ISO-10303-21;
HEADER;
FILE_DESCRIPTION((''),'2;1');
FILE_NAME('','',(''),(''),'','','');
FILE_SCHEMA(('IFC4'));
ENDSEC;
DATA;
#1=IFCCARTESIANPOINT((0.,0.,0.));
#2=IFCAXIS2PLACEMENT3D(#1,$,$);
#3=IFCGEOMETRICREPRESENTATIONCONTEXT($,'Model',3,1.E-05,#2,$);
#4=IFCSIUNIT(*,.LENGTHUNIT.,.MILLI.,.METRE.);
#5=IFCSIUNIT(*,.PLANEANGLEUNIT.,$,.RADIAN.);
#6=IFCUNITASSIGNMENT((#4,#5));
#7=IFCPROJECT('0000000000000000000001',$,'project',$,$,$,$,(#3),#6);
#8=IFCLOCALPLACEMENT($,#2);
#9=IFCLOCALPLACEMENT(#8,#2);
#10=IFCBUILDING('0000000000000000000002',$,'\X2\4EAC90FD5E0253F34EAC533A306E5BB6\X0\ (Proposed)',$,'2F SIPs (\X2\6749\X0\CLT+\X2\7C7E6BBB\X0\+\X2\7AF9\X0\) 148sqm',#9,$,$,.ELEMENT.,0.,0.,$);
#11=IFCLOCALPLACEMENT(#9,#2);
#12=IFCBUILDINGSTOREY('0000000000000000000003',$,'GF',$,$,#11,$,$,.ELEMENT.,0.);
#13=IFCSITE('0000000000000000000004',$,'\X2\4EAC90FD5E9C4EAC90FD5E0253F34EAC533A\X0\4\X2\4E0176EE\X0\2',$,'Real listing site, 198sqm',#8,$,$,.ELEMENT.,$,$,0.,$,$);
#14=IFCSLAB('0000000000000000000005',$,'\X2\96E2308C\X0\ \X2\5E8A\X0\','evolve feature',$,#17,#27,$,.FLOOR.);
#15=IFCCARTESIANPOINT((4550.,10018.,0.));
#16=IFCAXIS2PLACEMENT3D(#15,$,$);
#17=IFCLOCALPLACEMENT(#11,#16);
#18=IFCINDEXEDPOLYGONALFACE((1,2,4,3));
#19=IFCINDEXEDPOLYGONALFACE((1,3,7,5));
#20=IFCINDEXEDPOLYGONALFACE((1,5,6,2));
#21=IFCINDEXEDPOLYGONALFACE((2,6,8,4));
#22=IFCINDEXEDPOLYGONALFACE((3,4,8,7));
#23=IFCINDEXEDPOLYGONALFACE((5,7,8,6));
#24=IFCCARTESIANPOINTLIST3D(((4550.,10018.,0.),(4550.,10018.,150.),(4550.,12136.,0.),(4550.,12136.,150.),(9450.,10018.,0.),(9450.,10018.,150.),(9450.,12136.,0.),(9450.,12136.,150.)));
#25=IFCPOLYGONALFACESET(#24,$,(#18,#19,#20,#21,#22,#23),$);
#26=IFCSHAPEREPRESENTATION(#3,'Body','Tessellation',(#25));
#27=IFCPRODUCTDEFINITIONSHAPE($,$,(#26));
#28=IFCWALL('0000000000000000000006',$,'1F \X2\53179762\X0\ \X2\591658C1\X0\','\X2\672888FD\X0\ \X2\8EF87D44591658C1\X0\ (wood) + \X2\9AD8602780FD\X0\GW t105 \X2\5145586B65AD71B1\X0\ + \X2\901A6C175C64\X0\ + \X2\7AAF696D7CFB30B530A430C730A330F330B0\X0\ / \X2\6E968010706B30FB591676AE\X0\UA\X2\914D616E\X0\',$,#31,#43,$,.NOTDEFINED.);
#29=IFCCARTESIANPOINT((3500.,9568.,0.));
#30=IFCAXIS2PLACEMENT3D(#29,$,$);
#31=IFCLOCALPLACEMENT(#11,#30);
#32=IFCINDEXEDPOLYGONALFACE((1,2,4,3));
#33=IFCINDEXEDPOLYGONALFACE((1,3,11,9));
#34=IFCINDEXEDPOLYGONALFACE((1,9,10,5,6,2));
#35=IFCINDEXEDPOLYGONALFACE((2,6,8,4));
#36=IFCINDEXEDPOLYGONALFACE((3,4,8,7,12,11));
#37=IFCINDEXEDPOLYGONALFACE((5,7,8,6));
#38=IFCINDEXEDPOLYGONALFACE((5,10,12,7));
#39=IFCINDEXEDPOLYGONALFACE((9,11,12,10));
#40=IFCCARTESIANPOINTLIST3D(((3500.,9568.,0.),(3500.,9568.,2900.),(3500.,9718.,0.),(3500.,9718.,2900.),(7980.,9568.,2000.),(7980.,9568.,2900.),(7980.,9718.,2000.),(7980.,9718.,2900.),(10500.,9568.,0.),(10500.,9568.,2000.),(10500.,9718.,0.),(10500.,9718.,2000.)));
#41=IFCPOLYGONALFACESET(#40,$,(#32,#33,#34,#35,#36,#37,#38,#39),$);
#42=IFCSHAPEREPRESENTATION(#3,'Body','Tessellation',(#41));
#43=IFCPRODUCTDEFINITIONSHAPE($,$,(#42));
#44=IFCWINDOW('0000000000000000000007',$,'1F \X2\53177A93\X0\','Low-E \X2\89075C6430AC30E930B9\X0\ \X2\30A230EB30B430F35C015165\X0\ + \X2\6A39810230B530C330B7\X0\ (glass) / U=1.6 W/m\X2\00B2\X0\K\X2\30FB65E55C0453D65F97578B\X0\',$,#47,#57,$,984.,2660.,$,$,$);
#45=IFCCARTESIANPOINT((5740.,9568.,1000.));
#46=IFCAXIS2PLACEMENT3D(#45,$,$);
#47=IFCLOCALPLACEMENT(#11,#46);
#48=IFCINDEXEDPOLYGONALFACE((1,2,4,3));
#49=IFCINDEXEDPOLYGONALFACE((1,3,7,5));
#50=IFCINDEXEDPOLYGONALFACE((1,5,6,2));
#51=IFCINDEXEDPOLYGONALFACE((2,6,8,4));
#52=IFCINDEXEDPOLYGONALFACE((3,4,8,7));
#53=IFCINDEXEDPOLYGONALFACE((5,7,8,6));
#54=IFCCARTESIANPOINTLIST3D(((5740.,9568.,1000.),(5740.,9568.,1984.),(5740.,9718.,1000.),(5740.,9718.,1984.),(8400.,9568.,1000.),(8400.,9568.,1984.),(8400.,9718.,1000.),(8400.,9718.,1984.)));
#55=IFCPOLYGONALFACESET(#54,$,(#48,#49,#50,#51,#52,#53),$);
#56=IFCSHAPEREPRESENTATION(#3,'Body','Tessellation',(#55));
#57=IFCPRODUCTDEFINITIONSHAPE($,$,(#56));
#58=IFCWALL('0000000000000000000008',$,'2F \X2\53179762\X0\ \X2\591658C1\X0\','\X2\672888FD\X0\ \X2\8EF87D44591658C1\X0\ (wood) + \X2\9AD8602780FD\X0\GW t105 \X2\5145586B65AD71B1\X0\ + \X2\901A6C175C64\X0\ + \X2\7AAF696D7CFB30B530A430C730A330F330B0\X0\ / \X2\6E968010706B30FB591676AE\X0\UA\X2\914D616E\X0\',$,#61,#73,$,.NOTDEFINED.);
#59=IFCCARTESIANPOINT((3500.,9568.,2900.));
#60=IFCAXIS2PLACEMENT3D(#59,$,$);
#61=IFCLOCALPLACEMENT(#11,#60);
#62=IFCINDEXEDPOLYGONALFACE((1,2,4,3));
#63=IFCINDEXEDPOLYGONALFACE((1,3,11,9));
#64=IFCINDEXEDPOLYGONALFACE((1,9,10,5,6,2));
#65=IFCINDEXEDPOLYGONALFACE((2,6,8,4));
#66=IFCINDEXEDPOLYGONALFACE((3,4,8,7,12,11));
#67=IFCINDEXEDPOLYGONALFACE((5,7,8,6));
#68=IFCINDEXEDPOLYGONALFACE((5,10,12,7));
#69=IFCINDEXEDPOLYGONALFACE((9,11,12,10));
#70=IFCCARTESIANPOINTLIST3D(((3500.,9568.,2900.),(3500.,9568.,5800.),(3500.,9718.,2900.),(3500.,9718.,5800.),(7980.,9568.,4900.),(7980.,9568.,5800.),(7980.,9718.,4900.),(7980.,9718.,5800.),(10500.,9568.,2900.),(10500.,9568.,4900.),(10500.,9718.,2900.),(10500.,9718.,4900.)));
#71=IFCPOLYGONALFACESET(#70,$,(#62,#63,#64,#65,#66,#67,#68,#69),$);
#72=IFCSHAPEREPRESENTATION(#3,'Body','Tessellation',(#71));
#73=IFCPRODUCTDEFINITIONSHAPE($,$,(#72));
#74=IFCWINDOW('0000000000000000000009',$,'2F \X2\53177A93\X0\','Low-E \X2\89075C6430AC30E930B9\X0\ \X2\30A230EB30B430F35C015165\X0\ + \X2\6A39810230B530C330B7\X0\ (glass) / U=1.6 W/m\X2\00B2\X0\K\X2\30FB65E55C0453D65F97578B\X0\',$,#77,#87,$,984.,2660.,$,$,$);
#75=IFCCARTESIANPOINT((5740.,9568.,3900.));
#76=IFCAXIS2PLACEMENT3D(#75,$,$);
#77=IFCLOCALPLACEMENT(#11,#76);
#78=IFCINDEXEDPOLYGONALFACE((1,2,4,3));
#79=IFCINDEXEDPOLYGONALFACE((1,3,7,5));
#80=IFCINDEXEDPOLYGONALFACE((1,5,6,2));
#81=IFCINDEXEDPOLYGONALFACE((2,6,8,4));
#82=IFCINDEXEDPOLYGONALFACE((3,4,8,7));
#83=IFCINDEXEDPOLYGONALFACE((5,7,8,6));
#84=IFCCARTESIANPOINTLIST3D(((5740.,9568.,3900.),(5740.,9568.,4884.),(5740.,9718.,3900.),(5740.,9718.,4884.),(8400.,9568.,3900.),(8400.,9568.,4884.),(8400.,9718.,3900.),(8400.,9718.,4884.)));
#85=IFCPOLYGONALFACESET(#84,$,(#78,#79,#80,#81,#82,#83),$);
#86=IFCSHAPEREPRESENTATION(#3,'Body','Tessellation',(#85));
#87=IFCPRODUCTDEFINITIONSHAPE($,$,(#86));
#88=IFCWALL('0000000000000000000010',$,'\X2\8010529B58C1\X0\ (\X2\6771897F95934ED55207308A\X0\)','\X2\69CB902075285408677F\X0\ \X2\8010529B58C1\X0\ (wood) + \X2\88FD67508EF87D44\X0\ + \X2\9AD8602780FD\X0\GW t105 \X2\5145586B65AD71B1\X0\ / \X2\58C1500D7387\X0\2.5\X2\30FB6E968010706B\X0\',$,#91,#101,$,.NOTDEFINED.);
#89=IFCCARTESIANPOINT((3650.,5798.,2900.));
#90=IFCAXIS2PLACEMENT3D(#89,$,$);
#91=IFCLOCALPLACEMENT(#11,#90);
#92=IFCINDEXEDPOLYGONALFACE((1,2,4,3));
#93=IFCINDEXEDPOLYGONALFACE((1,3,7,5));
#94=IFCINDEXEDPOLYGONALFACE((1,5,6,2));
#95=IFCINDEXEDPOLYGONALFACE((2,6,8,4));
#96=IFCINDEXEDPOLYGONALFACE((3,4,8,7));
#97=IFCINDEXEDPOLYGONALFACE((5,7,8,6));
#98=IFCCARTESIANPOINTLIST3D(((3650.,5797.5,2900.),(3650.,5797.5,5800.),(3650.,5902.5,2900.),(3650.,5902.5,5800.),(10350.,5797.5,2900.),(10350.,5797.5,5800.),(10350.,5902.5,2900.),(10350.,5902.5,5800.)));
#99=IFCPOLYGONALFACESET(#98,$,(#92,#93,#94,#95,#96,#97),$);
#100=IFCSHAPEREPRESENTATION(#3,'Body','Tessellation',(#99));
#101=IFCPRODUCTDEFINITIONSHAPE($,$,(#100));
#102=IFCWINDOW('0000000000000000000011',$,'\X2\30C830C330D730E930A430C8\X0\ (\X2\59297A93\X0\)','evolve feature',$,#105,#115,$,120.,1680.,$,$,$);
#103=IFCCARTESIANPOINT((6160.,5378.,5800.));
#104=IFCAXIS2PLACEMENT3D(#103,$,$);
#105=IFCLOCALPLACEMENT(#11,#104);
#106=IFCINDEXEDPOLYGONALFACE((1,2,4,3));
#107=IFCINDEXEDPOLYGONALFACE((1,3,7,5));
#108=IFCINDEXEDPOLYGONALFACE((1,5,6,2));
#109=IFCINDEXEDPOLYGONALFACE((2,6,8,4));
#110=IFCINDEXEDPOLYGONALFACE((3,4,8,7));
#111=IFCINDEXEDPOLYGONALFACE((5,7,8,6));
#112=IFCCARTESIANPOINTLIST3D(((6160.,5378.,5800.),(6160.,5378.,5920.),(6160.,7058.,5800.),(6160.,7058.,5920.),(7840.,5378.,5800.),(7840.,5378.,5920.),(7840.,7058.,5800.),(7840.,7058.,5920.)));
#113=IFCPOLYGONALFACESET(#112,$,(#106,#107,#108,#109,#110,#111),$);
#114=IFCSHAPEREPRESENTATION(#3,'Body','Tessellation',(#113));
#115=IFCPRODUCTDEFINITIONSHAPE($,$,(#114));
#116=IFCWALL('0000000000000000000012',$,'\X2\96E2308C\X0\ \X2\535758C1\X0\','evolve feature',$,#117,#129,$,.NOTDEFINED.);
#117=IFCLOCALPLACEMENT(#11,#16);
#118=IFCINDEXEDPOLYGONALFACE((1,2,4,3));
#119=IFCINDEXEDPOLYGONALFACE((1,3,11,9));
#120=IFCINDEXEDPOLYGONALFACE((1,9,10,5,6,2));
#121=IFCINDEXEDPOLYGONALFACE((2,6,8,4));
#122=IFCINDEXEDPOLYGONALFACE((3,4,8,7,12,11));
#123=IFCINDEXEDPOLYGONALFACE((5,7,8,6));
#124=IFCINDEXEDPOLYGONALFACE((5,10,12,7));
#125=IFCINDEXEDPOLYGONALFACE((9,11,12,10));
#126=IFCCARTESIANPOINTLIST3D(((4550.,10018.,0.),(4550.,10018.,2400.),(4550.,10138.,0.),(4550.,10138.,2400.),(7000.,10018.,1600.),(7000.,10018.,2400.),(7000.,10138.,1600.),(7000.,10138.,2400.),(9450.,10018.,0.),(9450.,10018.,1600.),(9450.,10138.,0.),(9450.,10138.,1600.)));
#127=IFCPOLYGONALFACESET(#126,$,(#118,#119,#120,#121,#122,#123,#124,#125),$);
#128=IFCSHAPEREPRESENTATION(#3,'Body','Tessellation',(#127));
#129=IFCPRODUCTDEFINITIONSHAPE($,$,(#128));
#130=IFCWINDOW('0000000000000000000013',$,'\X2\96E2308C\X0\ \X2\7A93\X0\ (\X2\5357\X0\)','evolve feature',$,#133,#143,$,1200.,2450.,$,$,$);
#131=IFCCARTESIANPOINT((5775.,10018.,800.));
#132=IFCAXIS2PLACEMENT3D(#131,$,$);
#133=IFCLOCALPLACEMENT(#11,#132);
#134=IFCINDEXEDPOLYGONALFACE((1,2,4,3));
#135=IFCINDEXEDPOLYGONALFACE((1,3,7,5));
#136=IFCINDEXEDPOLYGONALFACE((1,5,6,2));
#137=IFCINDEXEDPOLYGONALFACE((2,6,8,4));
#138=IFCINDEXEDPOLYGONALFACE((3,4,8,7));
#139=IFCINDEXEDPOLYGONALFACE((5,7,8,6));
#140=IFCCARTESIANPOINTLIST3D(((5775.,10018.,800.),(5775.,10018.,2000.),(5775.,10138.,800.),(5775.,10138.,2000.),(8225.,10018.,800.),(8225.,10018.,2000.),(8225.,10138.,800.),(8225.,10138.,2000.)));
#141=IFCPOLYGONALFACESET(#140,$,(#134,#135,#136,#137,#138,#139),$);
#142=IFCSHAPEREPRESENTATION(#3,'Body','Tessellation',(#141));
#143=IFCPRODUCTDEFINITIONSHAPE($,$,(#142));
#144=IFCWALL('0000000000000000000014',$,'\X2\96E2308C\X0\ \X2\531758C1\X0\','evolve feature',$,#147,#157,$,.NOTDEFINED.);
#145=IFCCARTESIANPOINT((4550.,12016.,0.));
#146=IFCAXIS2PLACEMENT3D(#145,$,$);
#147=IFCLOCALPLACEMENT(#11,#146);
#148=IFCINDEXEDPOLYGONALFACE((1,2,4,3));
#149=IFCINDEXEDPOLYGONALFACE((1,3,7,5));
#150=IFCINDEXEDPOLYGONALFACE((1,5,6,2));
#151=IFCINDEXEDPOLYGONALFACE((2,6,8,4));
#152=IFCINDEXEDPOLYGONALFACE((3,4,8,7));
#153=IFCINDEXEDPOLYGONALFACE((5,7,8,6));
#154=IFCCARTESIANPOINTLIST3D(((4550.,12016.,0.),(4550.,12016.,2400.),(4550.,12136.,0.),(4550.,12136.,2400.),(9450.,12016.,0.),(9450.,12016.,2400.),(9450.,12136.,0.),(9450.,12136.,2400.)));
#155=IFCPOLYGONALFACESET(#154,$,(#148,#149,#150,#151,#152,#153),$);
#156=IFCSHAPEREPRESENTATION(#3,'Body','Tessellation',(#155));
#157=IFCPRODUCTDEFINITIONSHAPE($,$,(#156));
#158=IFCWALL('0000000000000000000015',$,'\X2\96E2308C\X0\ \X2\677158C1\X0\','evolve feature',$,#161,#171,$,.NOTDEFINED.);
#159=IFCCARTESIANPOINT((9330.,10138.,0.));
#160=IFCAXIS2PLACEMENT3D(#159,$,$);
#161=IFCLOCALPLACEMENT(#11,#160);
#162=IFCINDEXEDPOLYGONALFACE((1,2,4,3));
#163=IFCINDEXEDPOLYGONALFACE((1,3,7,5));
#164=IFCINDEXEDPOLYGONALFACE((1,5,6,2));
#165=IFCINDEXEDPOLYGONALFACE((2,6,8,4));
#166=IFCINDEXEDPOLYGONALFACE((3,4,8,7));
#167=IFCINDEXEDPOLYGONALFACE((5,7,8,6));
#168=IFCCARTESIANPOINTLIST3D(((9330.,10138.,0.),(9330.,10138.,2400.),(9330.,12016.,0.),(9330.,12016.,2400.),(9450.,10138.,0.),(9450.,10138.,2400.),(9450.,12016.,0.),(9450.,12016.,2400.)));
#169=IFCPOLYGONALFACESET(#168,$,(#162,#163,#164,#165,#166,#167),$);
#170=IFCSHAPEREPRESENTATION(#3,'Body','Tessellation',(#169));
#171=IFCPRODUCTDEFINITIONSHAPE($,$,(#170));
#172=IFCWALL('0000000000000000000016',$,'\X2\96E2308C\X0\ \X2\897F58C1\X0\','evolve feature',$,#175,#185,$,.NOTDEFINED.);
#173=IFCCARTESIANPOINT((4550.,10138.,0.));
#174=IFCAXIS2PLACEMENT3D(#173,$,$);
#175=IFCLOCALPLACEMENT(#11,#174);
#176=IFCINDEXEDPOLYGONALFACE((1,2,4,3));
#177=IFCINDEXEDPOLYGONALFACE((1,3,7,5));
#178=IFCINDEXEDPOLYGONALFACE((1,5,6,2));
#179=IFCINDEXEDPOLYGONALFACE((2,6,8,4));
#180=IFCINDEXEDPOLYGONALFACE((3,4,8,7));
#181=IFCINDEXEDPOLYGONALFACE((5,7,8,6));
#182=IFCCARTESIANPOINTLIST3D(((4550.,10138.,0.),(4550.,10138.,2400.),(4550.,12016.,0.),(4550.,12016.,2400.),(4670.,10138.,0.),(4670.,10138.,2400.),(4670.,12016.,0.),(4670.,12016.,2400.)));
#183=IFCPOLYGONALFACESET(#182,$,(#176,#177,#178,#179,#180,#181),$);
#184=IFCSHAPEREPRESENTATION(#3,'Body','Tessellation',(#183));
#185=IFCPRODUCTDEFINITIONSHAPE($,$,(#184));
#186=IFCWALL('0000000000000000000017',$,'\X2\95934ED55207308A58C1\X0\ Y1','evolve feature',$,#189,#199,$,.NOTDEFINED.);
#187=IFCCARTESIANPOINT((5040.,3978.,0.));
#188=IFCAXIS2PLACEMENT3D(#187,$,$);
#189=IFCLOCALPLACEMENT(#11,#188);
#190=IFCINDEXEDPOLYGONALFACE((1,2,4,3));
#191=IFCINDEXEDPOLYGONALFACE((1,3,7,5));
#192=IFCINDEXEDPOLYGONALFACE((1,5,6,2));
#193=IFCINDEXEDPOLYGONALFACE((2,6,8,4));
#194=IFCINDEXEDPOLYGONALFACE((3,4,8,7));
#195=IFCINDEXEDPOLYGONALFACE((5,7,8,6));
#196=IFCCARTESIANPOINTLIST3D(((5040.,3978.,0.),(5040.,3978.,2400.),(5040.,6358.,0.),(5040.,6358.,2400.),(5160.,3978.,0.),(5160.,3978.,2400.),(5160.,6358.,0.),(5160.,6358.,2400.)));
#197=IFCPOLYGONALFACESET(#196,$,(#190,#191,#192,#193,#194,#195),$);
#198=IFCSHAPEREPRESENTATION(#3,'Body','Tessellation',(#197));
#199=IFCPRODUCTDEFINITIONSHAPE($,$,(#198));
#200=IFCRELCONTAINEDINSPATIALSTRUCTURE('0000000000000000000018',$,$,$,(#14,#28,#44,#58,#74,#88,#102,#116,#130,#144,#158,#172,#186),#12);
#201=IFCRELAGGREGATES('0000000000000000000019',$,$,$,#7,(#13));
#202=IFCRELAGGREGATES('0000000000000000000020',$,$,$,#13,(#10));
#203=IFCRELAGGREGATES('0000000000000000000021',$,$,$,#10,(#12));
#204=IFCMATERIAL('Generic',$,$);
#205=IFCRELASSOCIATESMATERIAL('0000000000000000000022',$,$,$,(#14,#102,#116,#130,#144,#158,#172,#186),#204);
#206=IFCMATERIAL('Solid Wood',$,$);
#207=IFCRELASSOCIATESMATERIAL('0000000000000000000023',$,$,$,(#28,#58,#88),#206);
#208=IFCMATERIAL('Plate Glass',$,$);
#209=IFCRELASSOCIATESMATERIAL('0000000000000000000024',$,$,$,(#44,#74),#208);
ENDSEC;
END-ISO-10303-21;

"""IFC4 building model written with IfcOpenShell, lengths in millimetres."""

from ifc_helpers import new_model, si_unit, frame, frame_2d, origin, place, context, project, spatial, rectangle, extrude, material, element, fill, save


model = new_model("IFC4")

# Units and contexts
model_context = context("Model", 3, precision=1e-05, world=origin())
ifc_project = project(units=[si_unit("LENGTHUNIT", "METRE", prefix="MILLI"), si_unit("PLANEANGLEUNIT", "RADIAN")], contexts=[model_context])

# Site, building, storey
site_placement = place(None, origin())
site = spatial("IfcSite", under=ifc_project, at=site_placement, Name="京都府京都市右京区4丁目2", ObjectType="Real listing site, 198sqm", CompositionType="ELEMENT", RefElevation=0.0)
building_placement = place(site_placement, origin())
building = spatial("IfcBuilding", under=site, at=building_placement, Name="京都市右京区の家 (Proposed)", ObjectType="2F SIPs (杉CLT+籾殻+竹) 148sqm", CompositionType="ELEMENT", ElevationOfRefHeight=0.0, ElevationOfTerrain=0.0)
storey_placement = place(building_placement, origin())
storey = spatial("IfcBuildingStorey", under=building, at=storey_placement, Name="GF", CompositionType="ELEMENT", Elevation=0.0)

# Slab
ifc_material_1 = material(Name="Generic")
slab_placement = place(storey_placement, frame((4550.0, 10018.0, 0.0)))
element("IfcSlab", 1, at=slab_placement, inside=storey, material=ifc_material_1, Name="離れ 床", Description="evolve feature", PredefinedType="FLOOR", context=model_context, shape_type="SweptSolid", body=[
    extrude(rectangle(XDim=4900.0, YDim=2118.0, at=frame_2d((2450.0, 1059.0))), frame((4550.0, 10018.0, 0.0)), (0.0, 0.0, 1.0), 150.0),
])

# Wall, opening, window
ifc_material_2 = material(Name="Solid Wood")
wall_1_placement = place(storey_placement, frame((3500.0, 9568.0, 0.0)))
wall_1 = element("IfcWall", 2, at=wall_1_placement, inside=storey, material=ifc_material_2, Name="1F 北面 外壁", Description="木製 軸組外壁 (wood) + 高性能GW t105 充填断熱 + 通気層 + 窯業系サイディング / 準耐火・外皮UA配慮", PredefinedType="NOTDEFINED", context=model_context, shape_type="SweptSolid", body=[
    extrude(rectangle(XDim=7000.0, YDim=150.0, at=frame_2d((3500.0, 75.0))), frame((3500.0, 9568.0, 0.0)), (0.0, 0.0, 1.0), 2900.0),
])
opening_1_placement = place(storey_placement, frame((5740.0, 9568.0, 1000.0)))
opening_1 = element("IfcOpeningElement", 3, at=opening_1_placement, cuts=wall_1, PredefinedType="NOTDEFINED", context=model_context, shape_type="SweptSolid", body=[
    extrude(rectangle(XDim=2660.0, YDim=150.0, at=frame_2d((1330.0, 75.0))), frame((5740.0, 9568.0, 1000.0)), (0.0, 0.0, 1.0), 984.0),
])
ifc_material_3 = material(Name="Plate Glass")
window_1_placement = place(storey_placement, frame((5740.0, 9568.0, 1000.0)))
window_1 = element("IfcWindow", 4, at=window_1_placement, inside=storey, material=ifc_material_3, Name="1F 北窓", Description="Low-E 複層ガラス アルゴン封入 + 樹脂サッシ (glass) / U=1.6 W/m²K・日射取得型", OverallHeight=984.0, OverallWidth=2660.0, context=model_context, shape_type="SweptSolid", body=[
    extrude(rectangle(XDim=2660.0, YDim=150.0, at=frame_2d((1330.0, 75.0))), frame((5740.0, 9568.0, 1000.0)), (0.0, 0.0, 1.0), 984.0),
])
fill(opening_1, window_1)

# Wall, opening, window
wall_2_placement = place(storey_placement, frame((3500.0, 9568.0, 2900.0)))
wall_2 = element("IfcWall", 5, at=wall_2_placement, inside=storey, material=ifc_material_2, Name="2F 北面 外壁", Description="木製 軸組外壁 (wood) + 高性能GW t105 充填断熱 + 通気層 + 窯業系サイディング / 準耐火・外皮UA配慮", PredefinedType="NOTDEFINED", context=model_context, shape_type="SweptSolid", body=[
    extrude(rectangle(XDim=7000.0, YDim=150.0, at=frame_2d((3500.0, 75.0))), frame((3500.0, 9568.0, 2900.0)), (0.0, 0.0, 1.0), 2900.0),
])
opening_2_placement = place(storey_placement, frame((5740.0, 9568.0, 3900.0)))
opening_2 = element("IfcOpeningElement", 6, at=opening_2_placement, cuts=wall_2, PredefinedType="NOTDEFINED", context=model_context, shape_type="SweptSolid", body=[
    extrude(rectangle(XDim=2660.0, YDim=150.0, at=frame_2d((1330.0, 75.0))), frame((5740.0, 9568.0, 3900.0)), (0.0, 0.0, 1.0), 984.0),
])
window_2_placement = place(storey_placement, frame((5740.0, 9568.0, 3900.0)))
window_2 = element("IfcWindow", 7, at=window_2_placement, inside=storey, material=ifc_material_3, Name="2F 北窓", Description="Low-E 複層ガラス アルゴン封入 + 樹脂サッシ (glass) / U=1.6 W/m²K・日射取得型", OverallHeight=984.0, OverallWidth=2660.0, context=model_context, shape_type="SweptSolid", body=[
    extrude(rectangle(XDim=2660.0, YDim=150.0, at=frame_2d((1330.0, 75.0))), frame((5740.0, 9568.0, 3900.0)), (0.0, 0.0, 1.0), 984.0),
])
fill(opening_2, window_2)

# Wall
wall_3_placement = place(storey_placement, frame((3650.0, 5798.0, 2900.0)))
element("IfcWall", 8, at=wall_3_placement, inside=storey, material=ifc_material_2, Name="耐力壁 (東西間仕切り)", Description="構造用合板 耐力壁 (wood) + 製材軸組 + 高性能GW t105 充填断熱 / 壁倍率2.5・準耐火", PredefinedType="NOTDEFINED", context=model_context, shape_type="SweptSolid", body=[
    extrude(rectangle(XDim=6700.0, YDim=105.0, at=frame_2d((3350.0, 52.0))), frame((3650.0, 5798.0, 2900.0)), (0.0, 0.0, 1.0), 2900.0),
])

# Window
window_3_placement = place(storey_placement, frame((6160.0, 5378.0, 5800.0)))
element("IfcWindow", 9, at=window_3_placement, inside=storey, material=ifc_material_1, Name="トップライト (天窓)", Description="evolve feature", OverallHeight=120.0, OverallWidth=1680.0, context=model_context, shape_type="SweptSolid", body=[
    extrude(rectangle(XDim=1680.0, YDim=1680.0, at=frame_2d((840.0, 840.0))), frame((6160.0, 5378.0, 5800.0)), (0.0, 0.0, 1.0), 120.0),
])

# Wall, opening, window
wall_4_placement = place(storey_placement, frame((4550.0, 10018.0, 0.0)))
wall_4 = element("IfcWall", 10, at=wall_4_placement, inside=storey, material=ifc_material_1, Name="離れ 南壁", Description="evolve feature", PredefinedType="NOTDEFINED", context=model_context, shape_type="SweptSolid", body=[
    extrude(rectangle(XDim=4900.0, YDim=120.0, at=frame_2d((2450.0, 60.0))), frame((4550.0, 10018.0, 0.0)), (0.0, 0.0, 1.0), 2400.0),
])
opening_3_placement = place(storey_placement, frame((5775.0, 10018.0, 800.0)))
opening_3 = element("IfcOpeningElement", 11, at=opening_3_placement, cuts=wall_4, PredefinedType="NOTDEFINED", context=model_context, shape_type="SweptSolid", body=[
    extrude(rectangle(XDim=2450.0, YDim=120.0, at=frame_2d((1225.0, 60.0))), frame((5775.0, 10018.0, 800.0)), (0.0, 0.0, 1.0), 1200.0),
])
window_4_placement = place(storey_placement, frame((5775.0, 10018.0, 800.0)))
window_4 = element("IfcWindow", 12, at=window_4_placement, inside=storey, material=ifc_material_1, Name="離れ 窓 (南)", Description="evolve feature", OverallHeight=1200.0, OverallWidth=2450.0, context=model_context, shape_type="SweptSolid", body=[
    extrude(rectangle(XDim=2450.0, YDim=120.0, at=frame_2d((1225.0, 60.0))), frame((5775.0, 10018.0, 800.0)), (0.0, 0.0, 1.0), 1200.0),
])
fill(opening_3, window_4)

# Walls
wall_5_placement = place(storey_placement, frame((4550.0, 12016.0, 0.0)))
element("IfcWall", 13, at=wall_5_placement, inside=storey, material=ifc_material_1, Name="離れ 北壁", Description="evolve feature", PredefinedType="NOTDEFINED", context=model_context, shape_type="SweptSolid", body=[
    extrude(rectangle(XDim=4900.0, YDim=120.0, at=frame_2d((2450.0, 60.0))), frame((4550.0, 12016.0, 0.0)), (0.0, 0.0, 1.0), 2400.0),
])
wall_6_placement = place(storey_placement, frame((9330.0, 10138.0, 0.0)))
element("IfcWall", 14, at=wall_6_placement, inside=storey, material=ifc_material_1, Name="離れ 東壁", Description="evolve feature", PredefinedType="NOTDEFINED", context=model_context, shape_type="SweptSolid", body=[
    extrude(rectangle(XDim=120.0, YDim=1878.0, at=frame_2d((60.0, 939.0))), frame((9330.0, 10138.0, 0.0)), (0.0, 0.0, 1.0), 2400.0),
])
wall_7_placement = place(storey_placement, frame((4550.0, 10138.0, 0.0)))
element("IfcWall", 15, at=wall_7_placement, inside=storey, material=ifc_material_1, Name="離れ 西壁", Description="evolve feature", PredefinedType="NOTDEFINED", context=model_context, shape_type="SweptSolid", body=[
    extrude(rectangle(XDim=120.0, YDim=1878.0, at=frame_2d((60.0, 939.0))), frame((4550.0, 10138.0, 0.0)), (0.0, 0.0, 1.0), 2400.0),
])
wall_8_placement = place(storey_placement, frame((5040.0, 3978.0, 0.0)))
element("IfcWall", 16, at=wall_8_placement, inside=storey, material=ifc_material_1, Name="間仕切り壁 Y1", Description="evolve feature", PredefinedType="NOTDEFINED", context=model_context, shape_type="SweptSolid", body=[
    extrude(rectangle(XDim=120.0, YDim=2380.0, at=frame_2d((60.0, 1190.0))), frame((5040.0, 3978.0, 0.0)), (0.0, 0.0, 1.0), 2400.0),
])

save(model, "model.ifc")
